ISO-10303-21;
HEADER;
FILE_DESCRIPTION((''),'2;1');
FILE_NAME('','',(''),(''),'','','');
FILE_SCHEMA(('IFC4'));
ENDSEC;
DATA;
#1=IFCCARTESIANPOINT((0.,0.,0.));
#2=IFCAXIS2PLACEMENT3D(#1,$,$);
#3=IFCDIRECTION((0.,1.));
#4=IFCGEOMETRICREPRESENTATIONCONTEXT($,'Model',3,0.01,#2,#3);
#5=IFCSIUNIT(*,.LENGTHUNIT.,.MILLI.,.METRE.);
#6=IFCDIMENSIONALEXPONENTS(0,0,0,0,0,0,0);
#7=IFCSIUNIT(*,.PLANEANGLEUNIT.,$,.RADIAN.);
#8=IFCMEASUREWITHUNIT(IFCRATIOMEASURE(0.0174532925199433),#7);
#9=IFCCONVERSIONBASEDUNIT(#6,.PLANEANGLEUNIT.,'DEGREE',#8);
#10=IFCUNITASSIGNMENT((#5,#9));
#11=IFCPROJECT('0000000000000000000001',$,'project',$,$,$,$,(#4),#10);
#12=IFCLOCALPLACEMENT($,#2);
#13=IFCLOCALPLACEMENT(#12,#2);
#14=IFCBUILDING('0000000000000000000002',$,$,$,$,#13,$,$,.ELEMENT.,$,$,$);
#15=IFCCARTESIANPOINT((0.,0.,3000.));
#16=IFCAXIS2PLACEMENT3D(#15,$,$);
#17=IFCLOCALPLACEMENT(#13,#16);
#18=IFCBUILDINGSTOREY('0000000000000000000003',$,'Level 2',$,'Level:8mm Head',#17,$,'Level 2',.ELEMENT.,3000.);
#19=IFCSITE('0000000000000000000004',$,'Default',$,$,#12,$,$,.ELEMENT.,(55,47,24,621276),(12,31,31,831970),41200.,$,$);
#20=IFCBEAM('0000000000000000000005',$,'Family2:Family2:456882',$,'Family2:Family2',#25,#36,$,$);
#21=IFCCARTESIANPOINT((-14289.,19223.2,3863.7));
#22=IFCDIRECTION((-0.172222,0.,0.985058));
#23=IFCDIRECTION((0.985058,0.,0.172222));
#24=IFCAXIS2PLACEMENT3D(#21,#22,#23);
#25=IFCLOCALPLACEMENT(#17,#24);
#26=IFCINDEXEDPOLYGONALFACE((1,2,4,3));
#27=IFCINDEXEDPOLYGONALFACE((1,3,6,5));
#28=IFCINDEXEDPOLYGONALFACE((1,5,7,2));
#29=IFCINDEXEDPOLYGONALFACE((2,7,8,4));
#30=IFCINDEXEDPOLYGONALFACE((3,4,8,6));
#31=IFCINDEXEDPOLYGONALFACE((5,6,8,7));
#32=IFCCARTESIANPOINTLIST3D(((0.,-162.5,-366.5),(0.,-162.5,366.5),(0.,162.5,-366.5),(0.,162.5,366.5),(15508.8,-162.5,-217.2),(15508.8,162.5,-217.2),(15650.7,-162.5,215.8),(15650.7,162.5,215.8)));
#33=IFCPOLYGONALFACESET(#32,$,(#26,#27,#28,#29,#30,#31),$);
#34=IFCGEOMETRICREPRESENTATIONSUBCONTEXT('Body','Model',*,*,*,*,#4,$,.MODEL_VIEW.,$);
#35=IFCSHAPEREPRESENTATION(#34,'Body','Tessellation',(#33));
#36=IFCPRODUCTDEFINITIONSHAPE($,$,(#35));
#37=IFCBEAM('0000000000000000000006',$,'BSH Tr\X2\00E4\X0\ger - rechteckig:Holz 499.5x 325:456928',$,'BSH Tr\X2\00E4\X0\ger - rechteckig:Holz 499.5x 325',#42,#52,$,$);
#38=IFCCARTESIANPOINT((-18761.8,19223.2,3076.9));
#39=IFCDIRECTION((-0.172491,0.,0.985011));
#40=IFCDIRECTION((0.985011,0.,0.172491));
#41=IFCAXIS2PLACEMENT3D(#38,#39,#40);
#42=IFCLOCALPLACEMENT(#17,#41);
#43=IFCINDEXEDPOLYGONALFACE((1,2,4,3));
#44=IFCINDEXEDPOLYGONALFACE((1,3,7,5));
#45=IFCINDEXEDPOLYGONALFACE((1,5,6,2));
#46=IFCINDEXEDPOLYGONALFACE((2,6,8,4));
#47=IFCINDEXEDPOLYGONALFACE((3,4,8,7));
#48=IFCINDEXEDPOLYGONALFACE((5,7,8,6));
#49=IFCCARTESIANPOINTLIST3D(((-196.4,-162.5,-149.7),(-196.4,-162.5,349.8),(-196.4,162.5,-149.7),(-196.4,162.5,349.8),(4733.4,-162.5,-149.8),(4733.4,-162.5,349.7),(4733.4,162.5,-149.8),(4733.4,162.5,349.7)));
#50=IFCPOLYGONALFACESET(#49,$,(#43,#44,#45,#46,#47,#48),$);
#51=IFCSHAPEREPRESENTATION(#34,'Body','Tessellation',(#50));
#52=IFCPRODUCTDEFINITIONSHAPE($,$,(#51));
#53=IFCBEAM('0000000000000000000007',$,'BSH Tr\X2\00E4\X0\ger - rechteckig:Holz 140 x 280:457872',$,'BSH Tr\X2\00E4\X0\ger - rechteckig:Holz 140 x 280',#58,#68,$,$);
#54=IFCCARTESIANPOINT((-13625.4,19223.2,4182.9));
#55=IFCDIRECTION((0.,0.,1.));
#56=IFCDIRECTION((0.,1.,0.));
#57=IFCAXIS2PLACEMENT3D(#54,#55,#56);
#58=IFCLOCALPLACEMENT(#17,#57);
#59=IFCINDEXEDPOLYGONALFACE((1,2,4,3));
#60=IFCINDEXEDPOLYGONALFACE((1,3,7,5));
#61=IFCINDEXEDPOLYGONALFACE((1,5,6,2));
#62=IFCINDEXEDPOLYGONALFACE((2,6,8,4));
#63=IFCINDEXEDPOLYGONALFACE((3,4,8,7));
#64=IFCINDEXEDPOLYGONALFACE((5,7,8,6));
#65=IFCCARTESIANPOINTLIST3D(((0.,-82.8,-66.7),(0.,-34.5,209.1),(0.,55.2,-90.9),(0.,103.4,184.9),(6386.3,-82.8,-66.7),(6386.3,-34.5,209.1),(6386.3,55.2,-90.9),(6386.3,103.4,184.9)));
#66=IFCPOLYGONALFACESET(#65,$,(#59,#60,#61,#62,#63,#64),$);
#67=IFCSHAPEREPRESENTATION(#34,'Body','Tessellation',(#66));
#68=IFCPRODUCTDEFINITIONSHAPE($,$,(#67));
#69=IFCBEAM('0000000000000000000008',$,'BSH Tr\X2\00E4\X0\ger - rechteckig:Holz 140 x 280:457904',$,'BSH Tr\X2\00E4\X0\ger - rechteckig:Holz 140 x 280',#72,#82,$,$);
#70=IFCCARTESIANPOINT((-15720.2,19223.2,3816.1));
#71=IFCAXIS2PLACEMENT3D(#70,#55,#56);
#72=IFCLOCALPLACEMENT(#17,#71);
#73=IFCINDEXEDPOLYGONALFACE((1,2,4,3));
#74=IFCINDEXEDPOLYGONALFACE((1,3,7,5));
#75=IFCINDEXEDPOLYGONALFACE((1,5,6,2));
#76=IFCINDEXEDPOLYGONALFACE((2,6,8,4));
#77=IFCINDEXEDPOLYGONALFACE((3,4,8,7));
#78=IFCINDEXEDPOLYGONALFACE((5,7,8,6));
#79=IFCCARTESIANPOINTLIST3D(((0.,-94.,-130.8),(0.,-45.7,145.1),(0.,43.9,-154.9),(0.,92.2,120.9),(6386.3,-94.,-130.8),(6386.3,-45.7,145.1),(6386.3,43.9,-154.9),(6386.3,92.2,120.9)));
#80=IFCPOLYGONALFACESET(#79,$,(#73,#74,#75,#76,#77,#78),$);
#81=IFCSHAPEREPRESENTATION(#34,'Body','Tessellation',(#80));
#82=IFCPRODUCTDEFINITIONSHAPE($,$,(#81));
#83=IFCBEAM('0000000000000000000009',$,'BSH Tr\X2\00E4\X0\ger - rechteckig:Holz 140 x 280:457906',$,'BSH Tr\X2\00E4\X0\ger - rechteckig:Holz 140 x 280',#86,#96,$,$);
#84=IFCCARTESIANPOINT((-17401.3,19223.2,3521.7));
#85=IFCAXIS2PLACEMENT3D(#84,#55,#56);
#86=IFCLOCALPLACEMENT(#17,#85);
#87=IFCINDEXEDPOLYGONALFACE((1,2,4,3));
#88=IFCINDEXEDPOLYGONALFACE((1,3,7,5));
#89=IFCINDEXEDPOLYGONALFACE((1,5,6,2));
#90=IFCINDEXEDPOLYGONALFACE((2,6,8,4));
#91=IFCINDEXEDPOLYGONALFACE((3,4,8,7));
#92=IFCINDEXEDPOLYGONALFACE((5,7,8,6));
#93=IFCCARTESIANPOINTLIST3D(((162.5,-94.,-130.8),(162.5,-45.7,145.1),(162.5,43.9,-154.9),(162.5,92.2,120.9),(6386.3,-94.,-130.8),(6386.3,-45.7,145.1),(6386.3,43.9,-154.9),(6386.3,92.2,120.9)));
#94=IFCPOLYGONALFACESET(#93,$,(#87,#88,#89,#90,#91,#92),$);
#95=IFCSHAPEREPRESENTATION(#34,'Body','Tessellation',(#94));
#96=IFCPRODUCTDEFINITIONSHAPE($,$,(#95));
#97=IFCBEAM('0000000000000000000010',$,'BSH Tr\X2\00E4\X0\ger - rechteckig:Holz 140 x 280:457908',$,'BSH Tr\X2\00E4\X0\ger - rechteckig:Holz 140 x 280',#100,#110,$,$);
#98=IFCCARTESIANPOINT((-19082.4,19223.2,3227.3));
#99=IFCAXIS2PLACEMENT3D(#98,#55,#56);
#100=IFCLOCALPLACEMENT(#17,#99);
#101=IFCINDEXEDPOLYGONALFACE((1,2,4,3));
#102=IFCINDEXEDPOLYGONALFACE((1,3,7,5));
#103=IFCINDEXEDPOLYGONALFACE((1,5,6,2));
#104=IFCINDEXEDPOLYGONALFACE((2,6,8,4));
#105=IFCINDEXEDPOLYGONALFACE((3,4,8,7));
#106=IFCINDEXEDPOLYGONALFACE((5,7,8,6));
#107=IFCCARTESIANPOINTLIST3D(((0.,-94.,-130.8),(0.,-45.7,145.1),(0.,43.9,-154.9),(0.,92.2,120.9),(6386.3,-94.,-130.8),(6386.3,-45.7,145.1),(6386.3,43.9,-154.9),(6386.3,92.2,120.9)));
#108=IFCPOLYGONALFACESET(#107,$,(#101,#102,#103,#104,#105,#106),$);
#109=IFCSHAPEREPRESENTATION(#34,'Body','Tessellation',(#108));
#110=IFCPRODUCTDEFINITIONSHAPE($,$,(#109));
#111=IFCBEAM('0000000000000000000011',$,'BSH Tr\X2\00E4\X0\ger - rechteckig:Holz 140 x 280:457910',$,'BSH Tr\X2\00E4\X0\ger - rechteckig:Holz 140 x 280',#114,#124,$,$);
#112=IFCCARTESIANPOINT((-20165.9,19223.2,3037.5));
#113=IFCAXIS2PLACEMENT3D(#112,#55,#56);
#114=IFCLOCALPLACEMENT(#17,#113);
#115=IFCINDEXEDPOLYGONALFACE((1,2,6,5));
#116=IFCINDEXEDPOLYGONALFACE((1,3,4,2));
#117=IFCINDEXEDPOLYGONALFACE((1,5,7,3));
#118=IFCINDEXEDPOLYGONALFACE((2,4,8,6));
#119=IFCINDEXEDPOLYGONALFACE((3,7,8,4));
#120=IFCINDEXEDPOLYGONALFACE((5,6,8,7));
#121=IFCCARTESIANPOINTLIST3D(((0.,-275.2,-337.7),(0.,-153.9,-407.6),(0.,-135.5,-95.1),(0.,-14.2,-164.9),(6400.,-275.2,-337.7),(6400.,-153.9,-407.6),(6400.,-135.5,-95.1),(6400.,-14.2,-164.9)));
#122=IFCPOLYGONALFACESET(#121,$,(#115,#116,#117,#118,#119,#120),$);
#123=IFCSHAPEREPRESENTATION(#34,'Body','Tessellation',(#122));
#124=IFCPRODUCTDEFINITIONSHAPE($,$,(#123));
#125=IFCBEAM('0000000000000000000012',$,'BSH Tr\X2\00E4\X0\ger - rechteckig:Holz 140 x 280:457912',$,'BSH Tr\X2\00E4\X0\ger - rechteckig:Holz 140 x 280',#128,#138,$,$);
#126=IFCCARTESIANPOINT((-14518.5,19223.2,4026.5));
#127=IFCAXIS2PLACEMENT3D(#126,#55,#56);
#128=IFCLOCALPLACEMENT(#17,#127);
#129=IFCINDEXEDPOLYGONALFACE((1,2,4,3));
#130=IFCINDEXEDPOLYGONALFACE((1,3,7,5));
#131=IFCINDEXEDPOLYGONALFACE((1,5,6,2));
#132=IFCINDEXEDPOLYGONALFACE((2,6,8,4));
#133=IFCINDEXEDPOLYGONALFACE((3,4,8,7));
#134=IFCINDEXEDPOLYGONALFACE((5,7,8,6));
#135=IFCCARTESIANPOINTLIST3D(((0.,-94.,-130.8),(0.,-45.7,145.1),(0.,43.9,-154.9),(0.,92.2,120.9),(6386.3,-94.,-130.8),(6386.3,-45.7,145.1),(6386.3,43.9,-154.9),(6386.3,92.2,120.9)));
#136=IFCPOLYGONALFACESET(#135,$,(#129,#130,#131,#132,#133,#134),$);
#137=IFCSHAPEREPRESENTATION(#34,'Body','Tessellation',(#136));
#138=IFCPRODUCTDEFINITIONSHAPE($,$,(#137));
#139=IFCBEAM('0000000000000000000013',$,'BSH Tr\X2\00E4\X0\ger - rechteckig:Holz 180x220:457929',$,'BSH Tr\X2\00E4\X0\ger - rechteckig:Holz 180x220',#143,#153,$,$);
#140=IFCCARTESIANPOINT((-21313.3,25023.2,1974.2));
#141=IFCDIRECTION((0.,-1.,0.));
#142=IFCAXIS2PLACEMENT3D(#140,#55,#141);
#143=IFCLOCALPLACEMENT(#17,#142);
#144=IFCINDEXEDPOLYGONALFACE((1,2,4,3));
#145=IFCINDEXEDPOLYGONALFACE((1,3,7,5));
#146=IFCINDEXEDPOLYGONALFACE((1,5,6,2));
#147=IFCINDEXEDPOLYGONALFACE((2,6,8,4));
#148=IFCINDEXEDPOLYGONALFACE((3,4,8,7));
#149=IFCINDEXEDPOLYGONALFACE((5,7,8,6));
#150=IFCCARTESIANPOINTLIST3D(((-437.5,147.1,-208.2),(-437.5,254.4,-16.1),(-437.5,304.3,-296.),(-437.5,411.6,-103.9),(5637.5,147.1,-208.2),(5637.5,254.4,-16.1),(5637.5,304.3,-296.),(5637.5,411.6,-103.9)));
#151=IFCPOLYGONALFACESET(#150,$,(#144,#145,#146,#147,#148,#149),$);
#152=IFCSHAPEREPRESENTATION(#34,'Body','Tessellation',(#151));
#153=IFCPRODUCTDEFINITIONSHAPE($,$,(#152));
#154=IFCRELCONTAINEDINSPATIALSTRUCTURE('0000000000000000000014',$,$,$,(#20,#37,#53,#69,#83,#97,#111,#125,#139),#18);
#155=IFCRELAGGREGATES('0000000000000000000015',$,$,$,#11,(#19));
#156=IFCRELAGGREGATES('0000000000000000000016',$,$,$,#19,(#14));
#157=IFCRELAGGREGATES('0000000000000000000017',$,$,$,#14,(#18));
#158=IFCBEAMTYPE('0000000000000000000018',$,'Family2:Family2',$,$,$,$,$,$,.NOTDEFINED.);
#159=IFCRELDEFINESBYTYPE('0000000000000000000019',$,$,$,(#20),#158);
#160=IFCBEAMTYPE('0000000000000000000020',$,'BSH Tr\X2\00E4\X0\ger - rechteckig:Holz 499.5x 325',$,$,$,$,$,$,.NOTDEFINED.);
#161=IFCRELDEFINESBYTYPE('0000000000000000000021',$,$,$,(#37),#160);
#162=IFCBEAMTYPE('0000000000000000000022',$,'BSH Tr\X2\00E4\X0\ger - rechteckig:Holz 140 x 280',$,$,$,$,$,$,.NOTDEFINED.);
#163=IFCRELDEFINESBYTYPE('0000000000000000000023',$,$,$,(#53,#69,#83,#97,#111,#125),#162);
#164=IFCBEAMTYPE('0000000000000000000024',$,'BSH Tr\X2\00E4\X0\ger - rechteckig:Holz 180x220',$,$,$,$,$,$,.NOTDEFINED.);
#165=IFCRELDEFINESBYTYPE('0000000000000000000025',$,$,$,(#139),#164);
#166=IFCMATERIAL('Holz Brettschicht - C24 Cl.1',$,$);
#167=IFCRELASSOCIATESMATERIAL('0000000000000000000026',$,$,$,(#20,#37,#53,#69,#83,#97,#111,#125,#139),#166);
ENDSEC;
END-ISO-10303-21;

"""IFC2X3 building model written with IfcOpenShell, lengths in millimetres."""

from ifc_helpers import new_model, entity, si_unit, converted_unit, direction, frame, frame_2d, origin, origin_2d_with_axis, place, context, subcontext, project, spatial, polyline, rectangle, extrude, clip, bounded_halfspace, material, type_object, element, save


model = new_model("IFC2X3")

# Units and contexts
model_context = context("Model", 3, precision=0.01, world=origin(), true_north=direction((0.0, 1.0)))
body_context = subcontext(model_context, "Body", "Model", "MODEL_VIEW")
ifc_project = project(units=[si_unit("LENGTHUNIT", "METRE", prefix="MILLI"), converted_unit("PLANEANGLEUNIT", "DEGREE", entity("IfcRatioMeasure", 0.0174532925199433), si_unit("PLANEANGLEUNIT", "RADIAN"), dimensions=[0, 0, 0, 0, 0, 0, 0])], contexts=[model_context])

# Site, building, storey
site_placement = place(None, origin())
site = spatial("IfcSite", under=ifc_project, at=site_placement, Name="Default", CompositionType="ELEMENT", RefLatitude=(55, 47, 24, 621276), RefLongitude=(12, 31, 31, 831970), RefElevation=41200.0)
building_placement = place(site_placement, origin())
building = spatial("IfcBuilding", under=site, at=building_placement, CompositionType="ELEMENT")
storey_placement = place(building_placement, frame((0.0, 0.0, 3000.0)))
storey = spatial("IfcBuildingStorey", under=building, at=storey_placement, Name="Level 2", ObjectType="Level:8mm Head", LongName="Level 2", CompositionType="ELEMENT", Elevation=3000.0)

# Beams
ifc_material = material(Name="Holz Brettschicht - C24 Cl.1")
beam_type_1 = type_object("IfcBeamType", Name="Family2:Family2", PredefinedType="NOTDEFINED")
beam_1_placement = place(storey_placement, frame((-14289.0, 19223.2, 3863.7), z_axis=(-0.172222, 0.0, 0.985058), x_axis=(0.985058, 0.0, 0.172222)))
element("IfcBeam", 1, at=beam_1_placement, inside=storey, type_object=beam_type_1, material=ifc_material, Name="Family2:Family2:456882", ObjectType="Family2:Family2", context=body_context, shape_type="Clipping", body=[
    clip(clip(clip(extrude(rectangle(XDim=733.0, YDim=325.0, at=frame_2d((0.0, 0.0), x_axis=(0.0, 1.0))), frame((0.0, 0.0, 0.0), z_axis=(1.0, 0.0, 0.0), x_axis=(0.0, 1.0, 0.0)), (0.0, 0.0, 1.0), 15650.7), bounded_halfspace(frame((0.0, 0.0, -366.5), z_axis=(0.009627, 0.0, -0.999954), x_axis=(0.0, 1.0, 0.0)), False, frame((0.0, 0.0, 0.0), z_axis=(1.0, 0.0, 0.0), x_axis=(0.0, 1.0, 0.0)), polyline([(-162.5, -366.5), (162.5, -366.5), (162.5, -217.2), (-162.5, -217.2), (-162.5, -366.5)]))), bounded_halfspace(frame((15700.1, 0.0, 366.5), z_axis=(0.95028, 0.0, -0.311395), x_axis=(0.311395, 0.0, 0.95028)), False, frame((0.0, 0.0, 0.0), z_axis=(1.0, 0.0, 0.0), x_axis=(0.0, 1.0, 0.0)), polyline([(-162.5, 215.8), (-162.5, -217.2), (162.5, -217.2), (162.5, 215.8), (-162.5, 215.8)]))), bounded_halfspace(frame((0.0, 0.0, 366.5), z_axis=(0.009627, 0.0, 0.999954), x_axis=(0.0, -1.0, 0.0)), False, frame((0.0, 0.0, 0.0), z_axis=(1.0, 0.0, 0.0), x_axis=(0.0, 1.0, 0.0)), polyline([(162.5, 366.5), (-162.5, 366.5), (-162.5, 215.8), (162.5, 215.8), (162.5, 366.5)]))),
])
beam_type_2 = type_object("IfcBeamType", Name="BSH Träger - rechteckig:Holz 499.5x 325", PredefinedType="NOTDEFINED")
beam_2_placement = place(storey_placement, frame((-18761.8, 19223.2, 3076.9), z_axis=(-0.172491, 0.0, 0.985011), x_axis=(0.985011, 0.0, 0.172491)))
element("IfcBeam", 2, at=beam_2_placement, inside=storey, type_object=beam_type_2, material=ifc_material, Name="BSH Träger - rechteckig:Holz 499.5x 325:456928", ObjectType="BSH Träger - rechteckig:Holz 499.5x 325", context=body_context, shape_type="SweptSolid", body=[
    extrude(rectangle(XDim=499.5, YDim=325.0, at=origin_2d_with_axis()), frame((-196.4, 0.0, 100.0), z_axis=(1.0, 0.0, 0.0), x_axis=(0.0, 0.0, -1.0)), (0.0, 0.0, 1.0), 4929.8),
])
beam_type_3 = type_object("IfcBeamType", Name="BSH Träger - rechteckig:Holz 140 x 280", PredefinedType="NOTDEFINED")
beam_3_placement = place(storey_placement, frame((-13625.4, 19223.2, 4182.9), z_axis=(0.0, 0.0, 1.0), x_axis=(0.0, 1.0, 0.0)))
element("IfcBeam", 3, at=beam_3_placement, inside=storey, type_object=beam_type_3, material=ifc_material, Name="BSH Träger - rechteckig:Holz 140 x 280:457872", ObjectType="BSH Träger - rechteckig:Holz 140 x 280", context=body_context, shape_type="SweptSolid", body=[
    extrude(rectangle(XDim=280.0, YDim=140.0, at=origin_2d_with_axis()), frame((0.0, 10.3, 59.1), z_axis=(1.0, 0.0, 0.0), x_axis=(0.0, 0.172491, 0.985011)), (0.0, 0.0, 1.0), 6386.3),
])
beam_4_placement = place(storey_placement, frame((-15720.2, 19223.2, 3816.1), z_axis=(0.0, 0.0, 1.0), x_axis=(0.0, 1.0, 0.0)))
element("IfcBeam", 4, at=beam_4_placement, inside=storey, type_object=beam_type_3, material=ifc_material, Name="BSH Träger - rechteckig:Holz 140 x 280:457904", ObjectType="BSH Träger - rechteckig:Holz 140 x 280", context=body_context, shape_type="SweptSolid", body=[
    extrude(rectangle(XDim=280.0, YDim=140.0, at=origin_2d_with_axis()), frame((0.0, -0.9, -4.9), z_axis=(1.0, 0.0, 0.0), x_axis=(0.0, 0.172491, 0.985011)), (0.0, 0.0, 1.0), 6386.3),
])
beam_5_placement = place(storey_placement, frame((-17401.3, 19223.2, 3521.7), z_axis=(0.0, 0.0, 1.0), x_axis=(0.0, 1.0, 0.0)))
element("IfcBeam", 5, at=beam_5_placement, inside=storey, type_object=beam_type_3, material=ifc_material, Name="BSH Träger - rechteckig:Holz 140 x 280:457906", ObjectType="BSH Träger - rechteckig:Holz 140 x 280", context=body_context, shape_type="SweptSolid", body=[
    extrude(rectangle(XDim=280.0, YDim=140.0, at=frame_2d((0.0, 0.0), x_axis=(1.0, 0.0))), frame((162.5, -0.9, -4.9), z_axis=(1.0, 0.0, 0.0), x_axis=(0.0, 0.172491, 0.985011)), (0.0, 0.0, 1.0), 6223.8),
])
beam_6_placement = place(storey_placement, frame((-19082.4, 19223.2, 3227.3), z_axis=(0.0, 0.0, 1.0), x_axis=(0.0, 1.0, 0.0)))
element("IfcBeam", 6, at=beam_6_placement, inside=storey, type_object=beam_type_3, material=ifc_material, Name="BSH Träger - rechteckig:Holz 140 x 280:457908", ObjectType="BSH Träger - rechteckig:Holz 140 x 280", context=body_context, shape_type="SweptSolid", body=[
    extrude(rectangle(XDim=280.0, YDim=140.0, at=origin_2d_with_axis()), frame((0.0, -0.9, -4.9), z_axis=(1.0, 0.0, 0.0), x_axis=(0.0, 0.172491, 0.985011)), (0.0, 0.0, 1.0), 6386.3),
])
beam_7_placement = place(storey_placement, frame((-20165.9, 19223.2, 3037.5), z_axis=(0.0, 0.0, 1.0), x_axis=(0.0, 1.0, 0.0)))
element("IfcBeam", 7, at=beam_7_placement, inside=storey, type_object=beam_type_3, material=ifc_material, Name="BSH Träger - rechteckig:Holz 140 x 280:457910", ObjectType="BSH Träger - rechteckig:Holz 140 x 280", context=body_context, shape_type="SweptSolid", body=[
    extrude(rectangle(XDim=280.0, YDim=140.0, at=origin_2d_with_axis()), frame((0.0, -144.7, -251.3), z_axis=(1.0, 0.0, 0.0), x_axis=(0.0, 0.498982, 0.866612)), (0.0, 0.0, 1.0), 6400.0),
])
beam_8_placement = place(storey_placement, frame((-14518.5, 19223.2, 4026.5), z_axis=(0.0, 0.0, 1.0), x_axis=(0.0, 1.0, 0.0)))
element("IfcBeam", 8, at=beam_8_placement, inside=storey, type_object=beam_type_3, material=ifc_material, Name="BSH Träger - rechteckig:Holz 140 x 280:457912", ObjectType="BSH Träger - rechteckig:Holz 140 x 280", context=body_context, shape_type="SweptSolid", body=[
    extrude(rectangle(XDim=280.0, YDim=140.0, at=frame_2d((0.0, 0.0), x_axis=(1.0, 0.0))), frame((0.0, -0.9, -4.9), z_axis=(1.0, 0.0, 0.0), x_axis=(0.0, 0.172491, 0.985011)), (0.0, 0.0, 1.0), 6386.3),
])
beam_type_4 = type_object("IfcBeamType", Name="BSH Träger - rechteckig:Holz 180x220", PredefinedType="NOTDEFINED")
beam_9_placement = place(storey_placement, frame((-21313.3, 25023.2, 1974.2), z_axis=(0.0, 0.0, 1.0), x_axis=(0.0, -1.0, 0.0)))
element("IfcBeam", 9, at=beam_9_placement, inside=storey, type_object=beam_type_4, material=ifc_material, Name="BSH Träger - rechteckig:Holz 180x220:457929", ObjectType="BSH Träger - rechteckig:Holz 180x220", context=body_context, shape_type="SweptSolid", body=[
    extrude(rectangle(XDim=220.0, YDim=180.0, at=frame_2d((0.0, 0.0), x_axis=(1.0, 0.0))), frame((-437.5, 279.4, -156.1), z_axis=(1.0, 0.0, 0.0), x_axis=(0.0, 0.4877, 0.873011)), (0.0, 0.0, 1.0), 6075.0),
])

save(model, "model.ifc")
